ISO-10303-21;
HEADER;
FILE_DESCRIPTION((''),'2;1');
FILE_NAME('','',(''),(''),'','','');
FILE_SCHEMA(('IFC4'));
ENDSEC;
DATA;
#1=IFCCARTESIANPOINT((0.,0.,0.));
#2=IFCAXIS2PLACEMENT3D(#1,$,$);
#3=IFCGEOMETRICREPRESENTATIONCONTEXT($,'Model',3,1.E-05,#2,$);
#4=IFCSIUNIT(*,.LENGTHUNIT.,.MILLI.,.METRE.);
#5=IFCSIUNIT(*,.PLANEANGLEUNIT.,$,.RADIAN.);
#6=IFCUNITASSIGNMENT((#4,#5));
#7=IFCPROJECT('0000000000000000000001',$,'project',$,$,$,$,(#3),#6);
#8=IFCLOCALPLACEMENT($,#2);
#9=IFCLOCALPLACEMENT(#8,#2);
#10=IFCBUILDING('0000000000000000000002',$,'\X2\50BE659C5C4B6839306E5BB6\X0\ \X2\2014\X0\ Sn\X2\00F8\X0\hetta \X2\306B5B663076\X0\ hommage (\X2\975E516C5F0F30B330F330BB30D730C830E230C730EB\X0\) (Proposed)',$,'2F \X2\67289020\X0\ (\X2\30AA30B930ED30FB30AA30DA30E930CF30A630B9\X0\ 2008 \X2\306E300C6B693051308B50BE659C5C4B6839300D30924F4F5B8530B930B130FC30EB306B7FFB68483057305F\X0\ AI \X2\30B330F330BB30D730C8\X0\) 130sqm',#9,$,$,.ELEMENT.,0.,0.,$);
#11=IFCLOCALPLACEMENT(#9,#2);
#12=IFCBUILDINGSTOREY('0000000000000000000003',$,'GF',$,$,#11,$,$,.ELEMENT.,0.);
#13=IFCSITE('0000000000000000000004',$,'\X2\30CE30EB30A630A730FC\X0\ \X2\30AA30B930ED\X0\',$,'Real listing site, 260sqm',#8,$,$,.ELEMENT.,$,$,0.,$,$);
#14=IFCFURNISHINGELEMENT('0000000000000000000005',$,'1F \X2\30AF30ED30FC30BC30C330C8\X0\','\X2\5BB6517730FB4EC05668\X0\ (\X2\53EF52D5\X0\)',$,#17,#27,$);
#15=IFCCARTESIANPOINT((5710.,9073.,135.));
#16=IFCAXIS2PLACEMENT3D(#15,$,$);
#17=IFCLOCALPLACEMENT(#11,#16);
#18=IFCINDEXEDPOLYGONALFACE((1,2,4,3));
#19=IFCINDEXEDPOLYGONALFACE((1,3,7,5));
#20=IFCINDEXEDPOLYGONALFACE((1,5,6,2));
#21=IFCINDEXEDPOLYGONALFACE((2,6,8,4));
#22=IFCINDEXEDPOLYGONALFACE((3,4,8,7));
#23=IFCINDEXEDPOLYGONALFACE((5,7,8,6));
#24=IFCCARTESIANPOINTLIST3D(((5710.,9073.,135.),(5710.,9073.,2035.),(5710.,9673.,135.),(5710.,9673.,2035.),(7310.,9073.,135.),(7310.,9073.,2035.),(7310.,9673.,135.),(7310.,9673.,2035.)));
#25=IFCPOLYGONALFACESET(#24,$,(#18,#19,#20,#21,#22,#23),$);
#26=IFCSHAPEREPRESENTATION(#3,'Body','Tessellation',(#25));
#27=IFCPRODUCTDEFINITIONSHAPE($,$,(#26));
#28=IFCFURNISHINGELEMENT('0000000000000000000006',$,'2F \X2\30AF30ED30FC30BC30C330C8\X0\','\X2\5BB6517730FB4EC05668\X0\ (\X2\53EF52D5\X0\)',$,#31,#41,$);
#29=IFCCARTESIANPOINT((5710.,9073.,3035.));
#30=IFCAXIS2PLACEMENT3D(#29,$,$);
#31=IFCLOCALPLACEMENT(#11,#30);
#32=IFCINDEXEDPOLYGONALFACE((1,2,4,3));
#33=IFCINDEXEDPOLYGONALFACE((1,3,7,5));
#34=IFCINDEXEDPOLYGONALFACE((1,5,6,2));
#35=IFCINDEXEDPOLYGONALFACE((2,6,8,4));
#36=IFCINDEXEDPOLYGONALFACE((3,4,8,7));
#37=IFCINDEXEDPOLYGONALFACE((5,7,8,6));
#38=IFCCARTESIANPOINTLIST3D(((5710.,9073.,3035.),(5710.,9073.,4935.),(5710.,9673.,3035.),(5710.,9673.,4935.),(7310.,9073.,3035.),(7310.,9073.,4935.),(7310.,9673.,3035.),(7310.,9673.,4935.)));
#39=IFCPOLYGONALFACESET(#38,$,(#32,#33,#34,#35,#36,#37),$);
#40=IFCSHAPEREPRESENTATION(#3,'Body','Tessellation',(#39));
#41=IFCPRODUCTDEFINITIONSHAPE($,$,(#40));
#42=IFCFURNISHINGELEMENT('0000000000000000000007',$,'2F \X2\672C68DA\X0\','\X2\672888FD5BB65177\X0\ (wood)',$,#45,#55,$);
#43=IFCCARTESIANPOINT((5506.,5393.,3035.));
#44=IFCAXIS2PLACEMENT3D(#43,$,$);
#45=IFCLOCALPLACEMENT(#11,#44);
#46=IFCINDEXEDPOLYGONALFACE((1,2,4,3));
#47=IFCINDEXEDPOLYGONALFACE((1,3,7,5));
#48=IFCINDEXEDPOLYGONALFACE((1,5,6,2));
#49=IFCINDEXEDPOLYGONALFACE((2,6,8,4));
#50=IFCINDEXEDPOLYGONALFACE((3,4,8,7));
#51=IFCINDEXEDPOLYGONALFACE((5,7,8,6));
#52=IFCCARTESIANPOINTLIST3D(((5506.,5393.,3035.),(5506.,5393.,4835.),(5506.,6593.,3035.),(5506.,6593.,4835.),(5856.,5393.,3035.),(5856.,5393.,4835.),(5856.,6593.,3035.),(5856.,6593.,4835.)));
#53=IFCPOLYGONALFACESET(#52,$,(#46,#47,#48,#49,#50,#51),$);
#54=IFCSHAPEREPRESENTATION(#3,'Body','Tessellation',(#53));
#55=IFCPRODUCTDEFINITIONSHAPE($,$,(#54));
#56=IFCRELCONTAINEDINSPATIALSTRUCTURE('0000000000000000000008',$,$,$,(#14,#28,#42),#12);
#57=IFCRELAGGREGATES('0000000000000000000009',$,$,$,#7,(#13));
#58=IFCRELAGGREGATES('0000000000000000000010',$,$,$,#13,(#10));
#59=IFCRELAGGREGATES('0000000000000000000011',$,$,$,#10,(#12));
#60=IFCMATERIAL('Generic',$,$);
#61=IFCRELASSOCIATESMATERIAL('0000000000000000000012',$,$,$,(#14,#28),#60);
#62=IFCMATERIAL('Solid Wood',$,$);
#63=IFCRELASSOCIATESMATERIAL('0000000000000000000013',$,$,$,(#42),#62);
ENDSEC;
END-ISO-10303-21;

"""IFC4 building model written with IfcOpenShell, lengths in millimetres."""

from ifc_helpers import new_model, si_unit, frame, frame_2d, origin, place, context, project, spatial, rectangle, extrude, material, element, save


model = new_model("IFC4")

# Units and contexts
model_context = context("Model", 3, precision=1e-05, world=origin())
ifc_project = project(units=[si_unit("LENGTHUNIT", "METRE", prefix="MILLI"), si_unit("PLANEANGLEUNIT", "RADIAN")], contexts=[model_context])

# Site, building, storey
site_placement = place(None, origin())
site = spatial("IfcSite", under=ifc_project, at=site_placement, Name="ノルウェー オスロ", ObjectType="Real listing site, 260sqm", CompositionType="ELEMENT", RefElevation=0.0)
building_placement = place(site_placement, origin())
building = spatial("IfcBuilding", under=site, at=building_placement, Name="傾斜屋根の家 — Snøhetta に学ぶ hommage (非公式コンセプトモデル) (Proposed)", ObjectType="2F 木造 (オスロ・オペラハウス 2008 の「歩ける傾斜屋根」を住宅スケールに翻案した AI コンセプト) 130sqm", CompositionType="ELEMENT", ElevationOfRefHeight=0.0, ElevationOfTerrain=0.0)
storey_placement = place(building_placement, origin())
storey = spatial("IfcBuildingStorey", under=building, at=storey_placement, Name="GF", CompositionType="ELEMENT", Elevation=0.0)

# Shared definitions
ifc_material_1 = material(Name="Solid Wood")

# Shared definitions
ifc_material_2 = material(Name="Generic")

# Furnishing elements
furnishing_1_placement = place(storey_placement, frame((5710.0, 9073.0, 135.0)))
element("IfcFurnishingElement", 1, at=furnishing_1_placement, inside=storey, material=ifc_material_2, Name="1F クローゼット", Description="家具・什器 (可動)", context=model_context, shape_type="SweptSolid", body=[
    extrude(rectangle(XDim=1600.0, YDim=600.0, at=frame_2d((800.0, 300.0))), frame((5710.0, 9073.0, 135.0)), (0.0, 0.0, 1.0), 1900.0),
])
furnishing_2_placement = place(storey_placement, frame((5710.0, 9073.0, 3035.0)))
element("IfcFurnishingElement", 2, at=furnishing_2_placement, inside=storey, material=ifc_material_2, Name="2F クローゼット", Description="家具・什器 (可動)", context=model_context, shape_type="SweptSolid", body=[
    extrude(rectangle(XDim=1600.0, YDim=600.0, at=frame_2d((800.0, 300.0))), frame((5710.0, 9073.0, 3035.0)), (0.0, 0.0, 1.0), 1900.0),
])
furnishing_3_placement = place(storey_placement, frame((5506.0, 5393.0, 3035.0)))
element("IfcFurnishingElement", 3, at=furnishing_3_placement, inside=storey, material=ifc_material_1, Name="2F 本棚", Description="木製家具 (wood)", context=model_context, shape_type="SweptSolid", body=[
    extrude(rectangle(XDim=350.0, YDim=1200.0, at=frame_2d((175.0, 600.0))), frame((5506.0, 5393.0, 3035.0)), (0.0, 0.0, 1.0), 1800.0),
])

save(model, "model.ifc")
